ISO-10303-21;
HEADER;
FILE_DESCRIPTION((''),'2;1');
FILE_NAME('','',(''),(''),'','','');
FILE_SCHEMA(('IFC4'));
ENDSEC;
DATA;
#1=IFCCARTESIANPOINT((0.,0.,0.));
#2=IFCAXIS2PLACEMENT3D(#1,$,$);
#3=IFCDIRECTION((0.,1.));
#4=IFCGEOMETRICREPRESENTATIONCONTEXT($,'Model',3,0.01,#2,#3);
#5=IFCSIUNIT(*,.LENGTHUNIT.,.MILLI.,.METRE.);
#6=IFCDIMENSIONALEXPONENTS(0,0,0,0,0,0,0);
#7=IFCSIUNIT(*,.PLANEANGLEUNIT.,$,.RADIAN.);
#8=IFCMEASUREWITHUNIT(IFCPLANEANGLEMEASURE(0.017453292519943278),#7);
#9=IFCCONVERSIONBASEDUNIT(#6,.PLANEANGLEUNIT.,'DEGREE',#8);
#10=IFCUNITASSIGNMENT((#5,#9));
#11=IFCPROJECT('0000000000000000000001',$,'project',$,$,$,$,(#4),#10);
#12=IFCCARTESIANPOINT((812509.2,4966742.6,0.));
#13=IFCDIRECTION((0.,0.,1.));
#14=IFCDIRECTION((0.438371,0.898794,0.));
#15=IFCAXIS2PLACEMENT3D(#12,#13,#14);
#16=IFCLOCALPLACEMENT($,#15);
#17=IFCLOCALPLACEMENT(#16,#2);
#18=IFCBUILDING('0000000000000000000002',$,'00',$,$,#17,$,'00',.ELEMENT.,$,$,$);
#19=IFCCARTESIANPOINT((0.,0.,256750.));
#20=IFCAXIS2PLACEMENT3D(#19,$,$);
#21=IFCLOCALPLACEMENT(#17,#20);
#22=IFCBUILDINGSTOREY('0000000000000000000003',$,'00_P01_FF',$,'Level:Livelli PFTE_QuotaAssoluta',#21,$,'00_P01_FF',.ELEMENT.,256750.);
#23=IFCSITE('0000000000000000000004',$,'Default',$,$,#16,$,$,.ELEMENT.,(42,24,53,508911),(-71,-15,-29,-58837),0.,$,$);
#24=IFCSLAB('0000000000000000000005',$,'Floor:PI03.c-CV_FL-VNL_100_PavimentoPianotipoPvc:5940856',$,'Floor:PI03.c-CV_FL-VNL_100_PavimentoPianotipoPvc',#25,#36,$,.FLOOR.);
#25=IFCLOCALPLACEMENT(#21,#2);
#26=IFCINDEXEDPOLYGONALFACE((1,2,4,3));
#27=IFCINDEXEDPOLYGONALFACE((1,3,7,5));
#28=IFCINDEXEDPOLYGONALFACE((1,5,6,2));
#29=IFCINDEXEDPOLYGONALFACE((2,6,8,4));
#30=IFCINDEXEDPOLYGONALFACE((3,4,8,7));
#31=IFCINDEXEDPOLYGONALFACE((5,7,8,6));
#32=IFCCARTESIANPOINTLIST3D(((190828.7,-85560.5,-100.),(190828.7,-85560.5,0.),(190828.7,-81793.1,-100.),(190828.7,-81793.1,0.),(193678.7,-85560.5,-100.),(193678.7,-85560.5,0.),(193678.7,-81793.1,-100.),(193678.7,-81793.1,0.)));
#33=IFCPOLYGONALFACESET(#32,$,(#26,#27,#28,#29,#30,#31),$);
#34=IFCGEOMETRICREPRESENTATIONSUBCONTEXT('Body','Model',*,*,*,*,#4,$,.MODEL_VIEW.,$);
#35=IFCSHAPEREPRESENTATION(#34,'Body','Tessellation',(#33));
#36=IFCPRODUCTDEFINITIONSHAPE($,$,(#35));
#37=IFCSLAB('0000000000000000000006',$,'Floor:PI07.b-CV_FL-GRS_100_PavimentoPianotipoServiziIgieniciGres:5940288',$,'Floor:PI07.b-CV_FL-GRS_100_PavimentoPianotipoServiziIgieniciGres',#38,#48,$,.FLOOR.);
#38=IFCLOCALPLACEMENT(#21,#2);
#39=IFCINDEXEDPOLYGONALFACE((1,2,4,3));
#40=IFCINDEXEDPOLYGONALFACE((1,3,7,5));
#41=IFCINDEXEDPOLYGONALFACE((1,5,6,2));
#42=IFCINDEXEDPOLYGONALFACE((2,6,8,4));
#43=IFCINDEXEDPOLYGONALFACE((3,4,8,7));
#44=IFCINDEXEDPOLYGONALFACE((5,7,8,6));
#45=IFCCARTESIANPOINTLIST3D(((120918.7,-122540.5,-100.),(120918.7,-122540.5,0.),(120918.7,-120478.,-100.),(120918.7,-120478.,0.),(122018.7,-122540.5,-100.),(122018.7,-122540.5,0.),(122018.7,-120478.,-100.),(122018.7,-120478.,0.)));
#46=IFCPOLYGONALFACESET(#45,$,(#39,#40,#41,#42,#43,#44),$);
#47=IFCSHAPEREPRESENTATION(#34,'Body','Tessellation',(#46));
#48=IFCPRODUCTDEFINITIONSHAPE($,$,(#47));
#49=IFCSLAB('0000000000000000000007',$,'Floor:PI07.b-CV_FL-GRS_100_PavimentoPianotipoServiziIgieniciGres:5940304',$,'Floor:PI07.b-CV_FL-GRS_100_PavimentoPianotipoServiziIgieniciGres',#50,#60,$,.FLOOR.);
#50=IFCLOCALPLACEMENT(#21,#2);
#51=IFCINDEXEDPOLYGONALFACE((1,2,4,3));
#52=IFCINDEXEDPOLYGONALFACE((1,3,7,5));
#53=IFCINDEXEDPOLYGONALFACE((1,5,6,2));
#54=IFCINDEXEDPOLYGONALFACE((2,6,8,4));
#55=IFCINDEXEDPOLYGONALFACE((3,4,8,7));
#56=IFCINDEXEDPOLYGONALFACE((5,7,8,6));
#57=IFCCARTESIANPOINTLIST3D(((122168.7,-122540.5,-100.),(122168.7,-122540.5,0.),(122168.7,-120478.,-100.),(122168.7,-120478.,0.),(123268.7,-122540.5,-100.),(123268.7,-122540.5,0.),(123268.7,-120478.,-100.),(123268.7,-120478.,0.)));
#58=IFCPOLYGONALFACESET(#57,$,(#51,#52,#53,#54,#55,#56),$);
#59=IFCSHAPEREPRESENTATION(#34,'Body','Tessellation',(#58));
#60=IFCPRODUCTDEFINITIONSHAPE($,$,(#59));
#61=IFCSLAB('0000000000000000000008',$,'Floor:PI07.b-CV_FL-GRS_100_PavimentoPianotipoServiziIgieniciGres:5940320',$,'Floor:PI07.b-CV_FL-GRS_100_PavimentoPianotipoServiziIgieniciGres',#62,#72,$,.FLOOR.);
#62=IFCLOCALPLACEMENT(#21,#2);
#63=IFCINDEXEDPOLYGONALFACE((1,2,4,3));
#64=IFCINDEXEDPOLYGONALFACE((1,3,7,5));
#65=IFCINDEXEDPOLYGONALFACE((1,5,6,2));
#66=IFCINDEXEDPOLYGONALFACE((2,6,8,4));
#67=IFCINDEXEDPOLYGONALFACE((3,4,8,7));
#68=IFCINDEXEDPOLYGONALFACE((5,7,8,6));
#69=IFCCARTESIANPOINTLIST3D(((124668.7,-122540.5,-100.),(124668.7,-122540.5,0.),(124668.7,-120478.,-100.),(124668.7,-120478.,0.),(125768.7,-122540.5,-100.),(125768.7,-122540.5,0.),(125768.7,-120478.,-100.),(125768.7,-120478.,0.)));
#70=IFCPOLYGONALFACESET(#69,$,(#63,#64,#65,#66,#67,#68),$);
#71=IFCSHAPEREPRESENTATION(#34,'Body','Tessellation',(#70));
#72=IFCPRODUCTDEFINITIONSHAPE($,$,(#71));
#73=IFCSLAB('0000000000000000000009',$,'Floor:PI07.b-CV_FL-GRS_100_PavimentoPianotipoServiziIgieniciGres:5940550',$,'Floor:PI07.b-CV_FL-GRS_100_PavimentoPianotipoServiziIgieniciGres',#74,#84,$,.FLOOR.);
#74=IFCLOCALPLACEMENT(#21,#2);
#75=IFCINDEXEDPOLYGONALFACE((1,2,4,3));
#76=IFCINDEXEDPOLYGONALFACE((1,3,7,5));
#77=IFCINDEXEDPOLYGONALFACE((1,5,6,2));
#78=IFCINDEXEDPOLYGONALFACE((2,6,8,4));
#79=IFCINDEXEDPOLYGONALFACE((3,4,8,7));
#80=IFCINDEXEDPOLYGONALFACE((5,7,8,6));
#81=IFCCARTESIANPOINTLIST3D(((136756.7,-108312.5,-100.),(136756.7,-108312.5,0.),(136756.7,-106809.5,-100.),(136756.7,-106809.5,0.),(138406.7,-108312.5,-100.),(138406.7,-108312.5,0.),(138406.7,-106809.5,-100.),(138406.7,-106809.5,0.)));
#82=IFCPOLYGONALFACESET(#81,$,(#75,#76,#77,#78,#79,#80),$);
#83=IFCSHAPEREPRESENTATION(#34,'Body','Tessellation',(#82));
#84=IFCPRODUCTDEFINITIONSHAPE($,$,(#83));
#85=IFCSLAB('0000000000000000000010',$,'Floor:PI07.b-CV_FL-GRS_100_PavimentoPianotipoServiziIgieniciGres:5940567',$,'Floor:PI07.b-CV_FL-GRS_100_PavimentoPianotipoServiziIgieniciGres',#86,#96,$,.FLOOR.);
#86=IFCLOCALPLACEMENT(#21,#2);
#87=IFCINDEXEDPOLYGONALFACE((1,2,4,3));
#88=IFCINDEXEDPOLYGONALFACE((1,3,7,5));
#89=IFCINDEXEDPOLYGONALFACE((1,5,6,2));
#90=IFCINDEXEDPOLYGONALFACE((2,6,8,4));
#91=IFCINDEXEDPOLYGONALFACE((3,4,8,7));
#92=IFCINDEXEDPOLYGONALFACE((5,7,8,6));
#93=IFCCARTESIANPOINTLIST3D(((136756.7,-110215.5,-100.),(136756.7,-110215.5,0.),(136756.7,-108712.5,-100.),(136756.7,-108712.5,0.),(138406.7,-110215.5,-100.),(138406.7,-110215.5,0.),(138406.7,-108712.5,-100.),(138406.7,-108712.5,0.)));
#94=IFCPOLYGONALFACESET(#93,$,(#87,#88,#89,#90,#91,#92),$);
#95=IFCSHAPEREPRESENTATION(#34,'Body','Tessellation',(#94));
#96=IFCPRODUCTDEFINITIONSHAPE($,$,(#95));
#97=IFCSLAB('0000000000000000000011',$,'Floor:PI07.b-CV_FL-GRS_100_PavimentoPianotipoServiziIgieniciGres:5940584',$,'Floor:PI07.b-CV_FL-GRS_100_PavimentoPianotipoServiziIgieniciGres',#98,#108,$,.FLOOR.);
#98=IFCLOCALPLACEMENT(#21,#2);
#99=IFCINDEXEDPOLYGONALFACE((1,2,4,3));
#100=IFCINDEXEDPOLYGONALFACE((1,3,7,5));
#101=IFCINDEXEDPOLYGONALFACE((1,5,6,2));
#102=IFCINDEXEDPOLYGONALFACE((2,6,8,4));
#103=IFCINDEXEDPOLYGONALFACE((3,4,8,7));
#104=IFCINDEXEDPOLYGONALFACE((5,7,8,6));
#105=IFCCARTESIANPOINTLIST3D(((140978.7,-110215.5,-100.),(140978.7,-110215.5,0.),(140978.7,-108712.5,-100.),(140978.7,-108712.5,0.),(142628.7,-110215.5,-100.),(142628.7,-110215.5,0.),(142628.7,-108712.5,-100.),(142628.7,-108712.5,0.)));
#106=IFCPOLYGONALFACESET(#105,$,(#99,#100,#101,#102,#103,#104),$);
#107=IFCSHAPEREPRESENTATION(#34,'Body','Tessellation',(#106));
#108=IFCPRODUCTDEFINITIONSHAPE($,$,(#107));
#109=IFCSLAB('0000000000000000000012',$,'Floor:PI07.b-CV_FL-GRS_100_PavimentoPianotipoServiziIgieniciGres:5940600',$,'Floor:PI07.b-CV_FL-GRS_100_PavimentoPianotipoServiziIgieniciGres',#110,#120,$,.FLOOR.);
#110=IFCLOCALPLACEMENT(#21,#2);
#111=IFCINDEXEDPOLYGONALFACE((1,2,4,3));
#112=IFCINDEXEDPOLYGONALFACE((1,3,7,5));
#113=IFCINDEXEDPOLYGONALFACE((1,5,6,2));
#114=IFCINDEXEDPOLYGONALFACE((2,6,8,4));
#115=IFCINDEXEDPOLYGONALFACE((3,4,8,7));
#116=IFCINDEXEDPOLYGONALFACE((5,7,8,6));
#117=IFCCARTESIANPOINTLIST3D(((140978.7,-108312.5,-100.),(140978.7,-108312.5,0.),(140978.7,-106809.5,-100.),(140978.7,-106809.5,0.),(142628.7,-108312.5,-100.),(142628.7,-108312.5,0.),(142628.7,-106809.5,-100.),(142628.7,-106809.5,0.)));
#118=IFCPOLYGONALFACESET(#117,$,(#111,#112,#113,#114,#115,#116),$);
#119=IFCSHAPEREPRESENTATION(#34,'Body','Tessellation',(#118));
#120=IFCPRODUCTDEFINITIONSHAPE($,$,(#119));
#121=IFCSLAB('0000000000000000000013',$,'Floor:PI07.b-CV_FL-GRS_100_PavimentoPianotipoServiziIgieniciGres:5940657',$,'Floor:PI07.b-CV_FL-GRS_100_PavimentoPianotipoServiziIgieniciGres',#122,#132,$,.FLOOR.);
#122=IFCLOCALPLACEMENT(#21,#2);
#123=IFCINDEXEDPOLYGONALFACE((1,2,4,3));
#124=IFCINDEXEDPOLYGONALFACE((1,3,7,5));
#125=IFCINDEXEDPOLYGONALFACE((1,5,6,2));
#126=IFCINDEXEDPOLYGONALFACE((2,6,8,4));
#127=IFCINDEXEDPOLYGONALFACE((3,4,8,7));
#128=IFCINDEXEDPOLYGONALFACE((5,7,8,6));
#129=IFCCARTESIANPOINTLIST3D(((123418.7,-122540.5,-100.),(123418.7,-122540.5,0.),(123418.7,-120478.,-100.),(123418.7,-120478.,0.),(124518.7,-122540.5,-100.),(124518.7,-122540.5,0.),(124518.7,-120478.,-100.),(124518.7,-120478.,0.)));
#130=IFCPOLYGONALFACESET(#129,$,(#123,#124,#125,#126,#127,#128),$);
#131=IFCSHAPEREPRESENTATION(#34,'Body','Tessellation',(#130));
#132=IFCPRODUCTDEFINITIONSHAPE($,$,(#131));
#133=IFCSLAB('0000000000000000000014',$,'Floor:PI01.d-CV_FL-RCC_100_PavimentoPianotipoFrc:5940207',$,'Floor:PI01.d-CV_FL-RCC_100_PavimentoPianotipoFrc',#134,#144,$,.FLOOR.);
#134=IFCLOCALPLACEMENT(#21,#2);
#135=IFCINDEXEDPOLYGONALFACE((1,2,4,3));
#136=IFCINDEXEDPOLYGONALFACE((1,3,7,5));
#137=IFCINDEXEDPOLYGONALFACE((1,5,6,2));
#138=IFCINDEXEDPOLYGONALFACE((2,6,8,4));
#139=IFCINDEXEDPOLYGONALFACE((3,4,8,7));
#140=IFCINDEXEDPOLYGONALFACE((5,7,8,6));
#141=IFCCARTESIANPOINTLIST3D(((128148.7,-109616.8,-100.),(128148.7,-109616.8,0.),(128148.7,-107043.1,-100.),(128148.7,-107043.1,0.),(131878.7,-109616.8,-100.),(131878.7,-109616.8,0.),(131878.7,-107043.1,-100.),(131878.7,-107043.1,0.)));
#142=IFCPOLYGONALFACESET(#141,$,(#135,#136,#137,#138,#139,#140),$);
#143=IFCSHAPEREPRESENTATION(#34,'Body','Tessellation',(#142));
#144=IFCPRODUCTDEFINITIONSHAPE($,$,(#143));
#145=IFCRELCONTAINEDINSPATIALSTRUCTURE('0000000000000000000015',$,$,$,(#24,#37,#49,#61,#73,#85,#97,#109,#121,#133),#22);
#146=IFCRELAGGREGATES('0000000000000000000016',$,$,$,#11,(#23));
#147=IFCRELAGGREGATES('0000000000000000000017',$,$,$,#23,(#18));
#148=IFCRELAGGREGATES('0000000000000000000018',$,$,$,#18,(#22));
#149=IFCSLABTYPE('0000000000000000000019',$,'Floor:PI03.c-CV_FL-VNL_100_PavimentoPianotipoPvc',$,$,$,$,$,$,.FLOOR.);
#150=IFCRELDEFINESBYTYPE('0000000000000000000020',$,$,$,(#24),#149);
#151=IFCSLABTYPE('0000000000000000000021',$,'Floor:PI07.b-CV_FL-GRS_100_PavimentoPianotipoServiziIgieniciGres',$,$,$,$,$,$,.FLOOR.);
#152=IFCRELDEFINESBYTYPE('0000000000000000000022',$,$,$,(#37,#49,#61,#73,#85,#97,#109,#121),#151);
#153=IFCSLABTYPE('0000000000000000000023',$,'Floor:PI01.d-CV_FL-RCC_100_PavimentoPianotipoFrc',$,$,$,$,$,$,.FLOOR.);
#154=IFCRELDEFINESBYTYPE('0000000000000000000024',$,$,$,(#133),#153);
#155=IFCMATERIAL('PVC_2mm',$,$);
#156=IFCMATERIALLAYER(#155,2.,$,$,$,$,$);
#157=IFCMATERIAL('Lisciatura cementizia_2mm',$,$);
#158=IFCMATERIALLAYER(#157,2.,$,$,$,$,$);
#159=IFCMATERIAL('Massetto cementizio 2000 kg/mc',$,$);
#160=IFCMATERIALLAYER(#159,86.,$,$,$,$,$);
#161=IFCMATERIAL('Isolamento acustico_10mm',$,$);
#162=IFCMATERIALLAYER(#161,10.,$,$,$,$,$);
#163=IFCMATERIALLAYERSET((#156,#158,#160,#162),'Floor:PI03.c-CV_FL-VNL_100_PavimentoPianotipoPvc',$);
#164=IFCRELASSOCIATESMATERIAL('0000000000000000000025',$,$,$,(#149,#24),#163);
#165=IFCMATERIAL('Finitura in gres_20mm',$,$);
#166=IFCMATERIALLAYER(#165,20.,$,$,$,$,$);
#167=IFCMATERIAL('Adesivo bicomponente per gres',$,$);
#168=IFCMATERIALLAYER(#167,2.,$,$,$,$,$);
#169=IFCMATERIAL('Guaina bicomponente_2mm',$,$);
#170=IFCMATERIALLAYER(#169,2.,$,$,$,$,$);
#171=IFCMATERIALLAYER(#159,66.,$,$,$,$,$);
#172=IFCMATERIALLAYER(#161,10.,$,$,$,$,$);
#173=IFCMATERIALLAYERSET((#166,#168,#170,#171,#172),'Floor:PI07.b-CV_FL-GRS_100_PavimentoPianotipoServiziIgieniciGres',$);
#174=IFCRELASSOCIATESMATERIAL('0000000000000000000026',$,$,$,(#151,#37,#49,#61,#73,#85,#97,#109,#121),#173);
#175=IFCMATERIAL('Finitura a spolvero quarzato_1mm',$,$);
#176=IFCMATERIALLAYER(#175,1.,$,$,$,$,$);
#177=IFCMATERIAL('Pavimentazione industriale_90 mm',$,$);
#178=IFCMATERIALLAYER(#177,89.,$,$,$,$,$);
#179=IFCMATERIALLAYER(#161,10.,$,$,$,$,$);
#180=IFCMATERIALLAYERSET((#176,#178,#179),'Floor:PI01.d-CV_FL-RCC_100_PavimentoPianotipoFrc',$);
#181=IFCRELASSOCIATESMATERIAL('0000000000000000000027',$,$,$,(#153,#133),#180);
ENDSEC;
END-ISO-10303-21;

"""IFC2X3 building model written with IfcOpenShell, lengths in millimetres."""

from ifc_helpers import new_model, entity, si_unit, converted_unit, direction, frame, frame_2d, origin, origin_2d_with_axis, place, context, subcontext, project, spatial, rectangle, extrude, material, layer, layer_set, layer_usage, type_object, element, save


model = new_model("IFC2X3")

# Units and contexts
model_context = context("Model", 3, precision=0.01, world=origin(), true_north=direction((0.0, 1.0)))
body_context = subcontext(model_context, "Body", "Model", "MODEL_VIEW")
ifc_project = project(units=[si_unit("LENGTHUNIT", "METRE", prefix="MILLI"), converted_unit("PLANEANGLEUNIT", "DEGREE", entity("IfcPlaneAngleMeasure", 0.017453292519943278), si_unit("PLANEANGLEUNIT", "RADIAN"), dimensions=[0, 0, 0, 0, 0, 0, 0])], contexts=[model_context])

# Site, building, storey
site_placement = place(None, frame((812509.2, 4966742.6, 0.0), z_axis=(0.0, 0.0, 1.0), x_axis=(0.438371, 0.898794, 0.0)))
site = spatial("IfcSite", under=ifc_project, at=site_placement, Name="Default", CompositionType="ELEMENT", RefLatitude=(42, 24, 53, 508911), RefLongitude=(-71, -15, -29, -58837), RefElevation=0.0)
building_placement = place(site_placement, origin())
building = spatial("IfcBuilding", under=site, at=building_placement, Name="00", LongName="00", CompositionType="ELEMENT")
storey_placement = place(building_placement, frame((0.0, 0.0, 256750.0)))
storey = spatial("IfcBuildingStorey", under=building, at=storey_placement, Name="00_P01_FF", ObjectType="Level:Livelli PFTE_QuotaAssoluta", LongName="00_P01_FF", CompositionType="ELEMENT", Elevation=256750.0)

# Slabs
ifc_material_1 = material(Name="PVC_2mm")
ifc_layer_1 = layer(ifc_material_1, 2.0)
ifc_material_2 = material(Name="Lisciatura cementizia_2mm")
ifc_layer_2 = layer(ifc_material_2, 2.0)
ifc_material_3 = material(Name="Massetto cementizio 2000 kg/mc")
ifc_layer_3 = layer(ifc_material_3, 86.0)
ifc_material_4 = material(Name="Isolamento acustico_10mm")
ifc_layer_4 = layer(ifc_material_4, 10.0)
ifc_layer_set_1 = layer_set([ifc_layer_1, ifc_layer_2, ifc_layer_3, ifc_layer_4], Name="Floor:PI03.c-CV_FL-VNL_100_PavimentoPianotipoPvc")
slab_type_1 = type_object("IfcSlabType", Name="Floor:PI03.c-CV_FL-VNL_100_PavimentoPianotipoPvc", PredefinedType="FLOOR", material=ifc_layer_set_1)
ifc_layer_usage_1 = layer_usage(ifc_layer_set_1, "AXIS3", "POSITIVE", 0.0)
slab_1_placement = place(storey_placement, origin())
element("IfcSlab", 1, at=slab_1_placement, inside=storey, type_object=slab_type_1, material=ifc_layer_usage_1, Name="Floor:PI03.c-CV_FL-VNL_100_PavimentoPianotipoPvc:5940856", ObjectType="Floor:PI03.c-CV_FL-VNL_100_PavimentoPianotipoPvc", PredefinedType="FLOOR", context=body_context, shape_type="SweptSolid", body=[
    extrude(rectangle(XDim=3767.4, YDim=2850.0, at=frame_2d((0.0, 0.0), x_axis=(1.0, 0.0))), frame((192253.7, -83676.8, 0.0), z_axis=(0.0, 0.0, -1.0), x_axis=(0.0, 1.0, 0.0)), (0.0, 0.0, 1.0), 100.0),
])
ifc_material_5 = material(Name="Finitura in gres_20mm")
ifc_layer_5 = layer(ifc_material_5, 20.0)
ifc_material_6 = material(Name="Adesivo bicomponente per gres")
ifc_layer_6 = layer(ifc_material_6, 2.0)
ifc_material_7 = material(Name="Guaina bicomponente_2mm")
ifc_layer_7 = layer(ifc_material_7, 2.0)
ifc_layer_8 = layer(ifc_material_3, 66.0)
ifc_layer_9 = layer(ifc_material_4, 10.0)
ifc_layer_set_2 = layer_set([ifc_layer_5, ifc_layer_6, ifc_layer_7, ifc_layer_8, ifc_layer_9], Name="Floor:PI07.b-CV_FL-GRS_100_PavimentoPianotipoServiziIgieniciGres")
ifc_layer_usage_2 = layer_usage(ifc_layer_set_2, "AXIS3", "POSITIVE", 0.0)
slab_type_2 = type_object("IfcSlabType", Name="Floor:PI07.b-CV_FL-GRS_100_PavimentoPianotipoServiziIgieniciGres", PredefinedType="FLOOR", material=ifc_layer_set_2)
slab_2_placement = place(storey_placement, origin())
element("IfcSlab", 2, at=slab_2_placement, inside=storey, type_object=slab_type_2, material=ifc_layer_usage_2, Name="Floor:PI07.b-CV_FL-GRS_100_PavimentoPianotipoServiziIgieniciGres:5940288", ObjectType="Floor:PI07.b-CV_FL-GRS_100_PavimentoPianotipoServiziIgieniciGres", PredefinedType="FLOOR", context=body_context, shape_type="SweptSolid", body=[
    extrude(rectangle(XDim=2062.5, YDim=1100.0, at=frame_2d((0.0, 0.0), x_axis=(1.0, 0.0))), frame((121468.7, -121509.2, 0.0), z_axis=(0.0, 0.0, -1.0), x_axis=(0.0, 1.0, 0.0)), (0.0, 0.0, 1.0), 100.0),
])
ifc_layer_usage_3 = layer_usage(ifc_layer_set_2, "AXIS3", "POSITIVE", 0.0)
slab_3_placement = place(storey_placement, origin())
element("IfcSlab", 3, at=slab_3_placement, inside=storey, type_object=slab_type_2, material=ifc_layer_usage_3, Name="Floor:PI07.b-CV_FL-GRS_100_PavimentoPianotipoServiziIgieniciGres:5940304", ObjectType="Floor:PI07.b-CV_FL-GRS_100_PavimentoPianotipoServiziIgieniciGres", PredefinedType="FLOOR", context=body_context, shape_type="SweptSolid", body=[
    extrude(rectangle(XDim=2062.5, YDim=1100.0, at=origin_2d_with_axis()), frame((122718.7, -121509.2, 0.0), z_axis=(0.0, 0.0, -1.0), x_axis=(0.0, 1.0, 0.0)), (0.0, 0.0, 1.0), 100.0),
])
ifc_layer_usage_4 = layer_usage(ifc_layer_set_2, "AXIS3", "POSITIVE", 0.0)
slab_4_placement = place(storey_placement, origin())
element("IfcSlab", 4, at=slab_4_placement, inside=storey, type_object=slab_type_2, material=ifc_layer_usage_4, Name="Floor:PI07.b-CV_FL-GRS_100_PavimentoPianotipoServiziIgieniciGres:5940320", ObjectType="Floor:PI07.b-CV_FL-GRS_100_PavimentoPianotipoServiziIgieniciGres", PredefinedType="FLOOR", context=body_context, shape_type="SweptSolid", body=[
    extrude(rectangle(XDim=2062.5, YDim=1100.0, at=frame_2d((0.0, 0.0), x_axis=(1.0, 0.0))), frame((125218.7, -121509.2, 0.0), z_axis=(0.0, 0.0, -1.0), x_axis=(0.0, 1.0, 0.0)), (0.0, 0.0, 1.0), 100.0),
])
ifc_layer_usage_5 = layer_usage(ifc_layer_set_2, "AXIS3", "POSITIVE", 0.0)
slab_5_placement = place(storey_placement, origin())
element("IfcSlab", 5, at=slab_5_placement, inside=storey, type_object=slab_type_2, material=ifc_layer_usage_5, Name="Floor:PI07.b-CV_FL-GRS_100_PavimentoPianotipoServiziIgieniciGres:5940550", ObjectType="Floor:PI07.b-CV_FL-GRS_100_PavimentoPianotipoServiziIgieniciGres", PredefinedType="FLOOR", context=body_context, shape_type="SweptSolid", body=[
    extrude(rectangle(XDim=1650.0, YDim=1503.0, at=frame_2d((0.0, 0.0), x_axis=(1.0, 0.0))), frame((137581.7, -107561.0, 0.0), z_axis=(0.0, 0.0, -1.0), x_axis=(1.0, 0.0, 0.0)), (0.0, 0.0, 1.0), 100.0),
])
ifc_layer_usage_6 = layer_usage(ifc_layer_set_2, "AXIS3", "POSITIVE", 0.0)
slab_6_placement = place(storey_placement, origin())
element("IfcSlab", 6, at=slab_6_placement, inside=storey, type_object=slab_type_2, material=ifc_layer_usage_6, Name="Floor:PI07.b-CV_FL-GRS_100_PavimentoPianotipoServiziIgieniciGres:5940567", ObjectType="Floor:PI07.b-CV_FL-GRS_100_PavimentoPianotipoServiziIgieniciGres", PredefinedType="FLOOR", context=body_context, shape_type="SweptSolid", body=[
    extrude(rectangle(XDim=1650.0, YDim=1503.0, at=origin_2d_with_axis()), frame((137581.7, -109464.0, 0.0), z_axis=(0.0, 0.0, -1.0), x_axis=(1.0, 0.0, 0.0)), (0.0, 0.0, 1.0), 100.0),
])
ifc_layer_usage_7 = layer_usage(ifc_layer_set_2, "AXIS3", "POSITIVE", 0.0)
slab_7_placement = place(storey_placement, origin())
element("IfcSlab", 7, at=slab_7_placement, inside=storey, type_object=slab_type_2, material=ifc_layer_usage_7, Name="Floor:PI07.b-CV_FL-GRS_100_PavimentoPianotipoServiziIgieniciGres:5940584", ObjectType="Floor:PI07.b-CV_FL-GRS_100_PavimentoPianotipoServiziIgieniciGres", PredefinedType="FLOOR", context=body_context, shape_type="SweptSolid", body=[
    extrude(rectangle(XDim=1503.0, YDim=1650.0, at=origin_2d_with_axis()), frame((141803.7, -109464.0, 0.0), z_axis=(0.0, 0.0, -1.0), x_axis=(0.0, 1.0, 0.0)), (0.0, 0.0, 1.0), 100.0),
])
ifc_layer_usage_8 = layer_usage(ifc_layer_set_2, "AXIS3", "POSITIVE", 0.0)
slab_8_placement = place(storey_placement, origin())
element("IfcSlab", 8, at=slab_8_placement, inside=storey, type_object=slab_type_2, material=ifc_layer_usage_8, Name="Floor:PI07.b-CV_FL-GRS_100_PavimentoPianotipoServiziIgieniciGres:5940600", ObjectType="Floor:PI07.b-CV_FL-GRS_100_PavimentoPianotipoServiziIgieniciGres", PredefinedType="FLOOR", context=body_context, shape_type="SweptSolid", body=[
    extrude(rectangle(XDim=1503.0, YDim=1650.0, at=frame_2d((0.0, 0.0), x_axis=(1.0, 0.0))), frame((141803.7, -107561.0, 0.0), z_axis=(0.0, 0.0, -1.0), x_axis=(0.0, 1.0, 0.0)), (0.0, 0.0, 1.0), 100.0),
])
ifc_layer_usage_9 = layer_usage(ifc_layer_set_2, "AXIS3", "POSITIVE", 0.0)
slab_9_placement = place(storey_placement, origin())
element("IfcSlab", 9, at=slab_9_placement, inside=storey, type_object=slab_type_2, material=ifc_layer_usage_9, Name="Floor:PI07.b-CV_FL-GRS_100_PavimentoPianotipoServiziIgieniciGres:5940657", ObjectType="Floor:PI07.b-CV_FL-GRS_100_PavimentoPianotipoServiziIgieniciGres", PredefinedType="FLOOR", context=body_context, shape_type="SweptSolid", body=[
    extrude(rectangle(XDim=2062.5, YDim=1100.0, at=frame_2d((0.0, 0.0), x_axis=(1.0, 0.0))), frame((123968.7, -121509.2, 0.0), z_axis=(0.0, 0.0, -1.0), x_axis=(0.0, 1.0, 0.0)), (0.0, 0.0, 1.0), 100.0),
])
ifc_material_8 = material(Name="Finitura a spolvero quarzato_1mm")
ifc_layer_10 = layer(ifc_material_8, 1.0)
ifc_material_9 = material(Name="Pavimentazione industriale_90 mm")
ifc_layer_11 = layer(ifc_material_9, 89.0)
ifc_layer_12 = layer(ifc_material_4, 10.0)
ifc_layer_set_3 = layer_set([ifc_layer_10, ifc_layer_11, ifc_layer_12], Name="Floor:PI01.d-CV_FL-RCC_100_PavimentoPianotipoFrc")
slab_type_3 = type_object("IfcSlabType", Name="Floor:PI01.d-CV_FL-RCC_100_PavimentoPianotipoFrc", PredefinedType="FLOOR", material=ifc_layer_set_3)
ifc_layer_usage_10 = layer_usage(ifc_layer_set_3, "AXIS3", "POSITIVE", 0.0)
slab_10_placement = place(storey_placement, origin())
element("IfcSlab", 10, at=slab_10_placement, inside=storey, type_object=slab_type_3, material=ifc_layer_usage_10, Name="Floor:PI01.d-CV_FL-RCC_100_PavimentoPianotipoFrc:5940207", ObjectType="Floor:PI01.d-CV_FL-RCC_100_PavimentoPianotipoFrc", PredefinedType="FLOOR", context=body_context, shape_type="SweptSolid", body=[
    extrude(rectangle(XDim=2573.7, YDim=3730.0, at=frame_2d((0.0, 0.0), x_axis=(1.0, 0.0))), frame((130013.7, -108329.9, 0.0), z_axis=(0.0, 0.0, -1.0), x_axis=(0.0, 1.0, 0.0)), (0.0, 0.0, 1.0), 100.0),
])

save(model, "model.ifc")
